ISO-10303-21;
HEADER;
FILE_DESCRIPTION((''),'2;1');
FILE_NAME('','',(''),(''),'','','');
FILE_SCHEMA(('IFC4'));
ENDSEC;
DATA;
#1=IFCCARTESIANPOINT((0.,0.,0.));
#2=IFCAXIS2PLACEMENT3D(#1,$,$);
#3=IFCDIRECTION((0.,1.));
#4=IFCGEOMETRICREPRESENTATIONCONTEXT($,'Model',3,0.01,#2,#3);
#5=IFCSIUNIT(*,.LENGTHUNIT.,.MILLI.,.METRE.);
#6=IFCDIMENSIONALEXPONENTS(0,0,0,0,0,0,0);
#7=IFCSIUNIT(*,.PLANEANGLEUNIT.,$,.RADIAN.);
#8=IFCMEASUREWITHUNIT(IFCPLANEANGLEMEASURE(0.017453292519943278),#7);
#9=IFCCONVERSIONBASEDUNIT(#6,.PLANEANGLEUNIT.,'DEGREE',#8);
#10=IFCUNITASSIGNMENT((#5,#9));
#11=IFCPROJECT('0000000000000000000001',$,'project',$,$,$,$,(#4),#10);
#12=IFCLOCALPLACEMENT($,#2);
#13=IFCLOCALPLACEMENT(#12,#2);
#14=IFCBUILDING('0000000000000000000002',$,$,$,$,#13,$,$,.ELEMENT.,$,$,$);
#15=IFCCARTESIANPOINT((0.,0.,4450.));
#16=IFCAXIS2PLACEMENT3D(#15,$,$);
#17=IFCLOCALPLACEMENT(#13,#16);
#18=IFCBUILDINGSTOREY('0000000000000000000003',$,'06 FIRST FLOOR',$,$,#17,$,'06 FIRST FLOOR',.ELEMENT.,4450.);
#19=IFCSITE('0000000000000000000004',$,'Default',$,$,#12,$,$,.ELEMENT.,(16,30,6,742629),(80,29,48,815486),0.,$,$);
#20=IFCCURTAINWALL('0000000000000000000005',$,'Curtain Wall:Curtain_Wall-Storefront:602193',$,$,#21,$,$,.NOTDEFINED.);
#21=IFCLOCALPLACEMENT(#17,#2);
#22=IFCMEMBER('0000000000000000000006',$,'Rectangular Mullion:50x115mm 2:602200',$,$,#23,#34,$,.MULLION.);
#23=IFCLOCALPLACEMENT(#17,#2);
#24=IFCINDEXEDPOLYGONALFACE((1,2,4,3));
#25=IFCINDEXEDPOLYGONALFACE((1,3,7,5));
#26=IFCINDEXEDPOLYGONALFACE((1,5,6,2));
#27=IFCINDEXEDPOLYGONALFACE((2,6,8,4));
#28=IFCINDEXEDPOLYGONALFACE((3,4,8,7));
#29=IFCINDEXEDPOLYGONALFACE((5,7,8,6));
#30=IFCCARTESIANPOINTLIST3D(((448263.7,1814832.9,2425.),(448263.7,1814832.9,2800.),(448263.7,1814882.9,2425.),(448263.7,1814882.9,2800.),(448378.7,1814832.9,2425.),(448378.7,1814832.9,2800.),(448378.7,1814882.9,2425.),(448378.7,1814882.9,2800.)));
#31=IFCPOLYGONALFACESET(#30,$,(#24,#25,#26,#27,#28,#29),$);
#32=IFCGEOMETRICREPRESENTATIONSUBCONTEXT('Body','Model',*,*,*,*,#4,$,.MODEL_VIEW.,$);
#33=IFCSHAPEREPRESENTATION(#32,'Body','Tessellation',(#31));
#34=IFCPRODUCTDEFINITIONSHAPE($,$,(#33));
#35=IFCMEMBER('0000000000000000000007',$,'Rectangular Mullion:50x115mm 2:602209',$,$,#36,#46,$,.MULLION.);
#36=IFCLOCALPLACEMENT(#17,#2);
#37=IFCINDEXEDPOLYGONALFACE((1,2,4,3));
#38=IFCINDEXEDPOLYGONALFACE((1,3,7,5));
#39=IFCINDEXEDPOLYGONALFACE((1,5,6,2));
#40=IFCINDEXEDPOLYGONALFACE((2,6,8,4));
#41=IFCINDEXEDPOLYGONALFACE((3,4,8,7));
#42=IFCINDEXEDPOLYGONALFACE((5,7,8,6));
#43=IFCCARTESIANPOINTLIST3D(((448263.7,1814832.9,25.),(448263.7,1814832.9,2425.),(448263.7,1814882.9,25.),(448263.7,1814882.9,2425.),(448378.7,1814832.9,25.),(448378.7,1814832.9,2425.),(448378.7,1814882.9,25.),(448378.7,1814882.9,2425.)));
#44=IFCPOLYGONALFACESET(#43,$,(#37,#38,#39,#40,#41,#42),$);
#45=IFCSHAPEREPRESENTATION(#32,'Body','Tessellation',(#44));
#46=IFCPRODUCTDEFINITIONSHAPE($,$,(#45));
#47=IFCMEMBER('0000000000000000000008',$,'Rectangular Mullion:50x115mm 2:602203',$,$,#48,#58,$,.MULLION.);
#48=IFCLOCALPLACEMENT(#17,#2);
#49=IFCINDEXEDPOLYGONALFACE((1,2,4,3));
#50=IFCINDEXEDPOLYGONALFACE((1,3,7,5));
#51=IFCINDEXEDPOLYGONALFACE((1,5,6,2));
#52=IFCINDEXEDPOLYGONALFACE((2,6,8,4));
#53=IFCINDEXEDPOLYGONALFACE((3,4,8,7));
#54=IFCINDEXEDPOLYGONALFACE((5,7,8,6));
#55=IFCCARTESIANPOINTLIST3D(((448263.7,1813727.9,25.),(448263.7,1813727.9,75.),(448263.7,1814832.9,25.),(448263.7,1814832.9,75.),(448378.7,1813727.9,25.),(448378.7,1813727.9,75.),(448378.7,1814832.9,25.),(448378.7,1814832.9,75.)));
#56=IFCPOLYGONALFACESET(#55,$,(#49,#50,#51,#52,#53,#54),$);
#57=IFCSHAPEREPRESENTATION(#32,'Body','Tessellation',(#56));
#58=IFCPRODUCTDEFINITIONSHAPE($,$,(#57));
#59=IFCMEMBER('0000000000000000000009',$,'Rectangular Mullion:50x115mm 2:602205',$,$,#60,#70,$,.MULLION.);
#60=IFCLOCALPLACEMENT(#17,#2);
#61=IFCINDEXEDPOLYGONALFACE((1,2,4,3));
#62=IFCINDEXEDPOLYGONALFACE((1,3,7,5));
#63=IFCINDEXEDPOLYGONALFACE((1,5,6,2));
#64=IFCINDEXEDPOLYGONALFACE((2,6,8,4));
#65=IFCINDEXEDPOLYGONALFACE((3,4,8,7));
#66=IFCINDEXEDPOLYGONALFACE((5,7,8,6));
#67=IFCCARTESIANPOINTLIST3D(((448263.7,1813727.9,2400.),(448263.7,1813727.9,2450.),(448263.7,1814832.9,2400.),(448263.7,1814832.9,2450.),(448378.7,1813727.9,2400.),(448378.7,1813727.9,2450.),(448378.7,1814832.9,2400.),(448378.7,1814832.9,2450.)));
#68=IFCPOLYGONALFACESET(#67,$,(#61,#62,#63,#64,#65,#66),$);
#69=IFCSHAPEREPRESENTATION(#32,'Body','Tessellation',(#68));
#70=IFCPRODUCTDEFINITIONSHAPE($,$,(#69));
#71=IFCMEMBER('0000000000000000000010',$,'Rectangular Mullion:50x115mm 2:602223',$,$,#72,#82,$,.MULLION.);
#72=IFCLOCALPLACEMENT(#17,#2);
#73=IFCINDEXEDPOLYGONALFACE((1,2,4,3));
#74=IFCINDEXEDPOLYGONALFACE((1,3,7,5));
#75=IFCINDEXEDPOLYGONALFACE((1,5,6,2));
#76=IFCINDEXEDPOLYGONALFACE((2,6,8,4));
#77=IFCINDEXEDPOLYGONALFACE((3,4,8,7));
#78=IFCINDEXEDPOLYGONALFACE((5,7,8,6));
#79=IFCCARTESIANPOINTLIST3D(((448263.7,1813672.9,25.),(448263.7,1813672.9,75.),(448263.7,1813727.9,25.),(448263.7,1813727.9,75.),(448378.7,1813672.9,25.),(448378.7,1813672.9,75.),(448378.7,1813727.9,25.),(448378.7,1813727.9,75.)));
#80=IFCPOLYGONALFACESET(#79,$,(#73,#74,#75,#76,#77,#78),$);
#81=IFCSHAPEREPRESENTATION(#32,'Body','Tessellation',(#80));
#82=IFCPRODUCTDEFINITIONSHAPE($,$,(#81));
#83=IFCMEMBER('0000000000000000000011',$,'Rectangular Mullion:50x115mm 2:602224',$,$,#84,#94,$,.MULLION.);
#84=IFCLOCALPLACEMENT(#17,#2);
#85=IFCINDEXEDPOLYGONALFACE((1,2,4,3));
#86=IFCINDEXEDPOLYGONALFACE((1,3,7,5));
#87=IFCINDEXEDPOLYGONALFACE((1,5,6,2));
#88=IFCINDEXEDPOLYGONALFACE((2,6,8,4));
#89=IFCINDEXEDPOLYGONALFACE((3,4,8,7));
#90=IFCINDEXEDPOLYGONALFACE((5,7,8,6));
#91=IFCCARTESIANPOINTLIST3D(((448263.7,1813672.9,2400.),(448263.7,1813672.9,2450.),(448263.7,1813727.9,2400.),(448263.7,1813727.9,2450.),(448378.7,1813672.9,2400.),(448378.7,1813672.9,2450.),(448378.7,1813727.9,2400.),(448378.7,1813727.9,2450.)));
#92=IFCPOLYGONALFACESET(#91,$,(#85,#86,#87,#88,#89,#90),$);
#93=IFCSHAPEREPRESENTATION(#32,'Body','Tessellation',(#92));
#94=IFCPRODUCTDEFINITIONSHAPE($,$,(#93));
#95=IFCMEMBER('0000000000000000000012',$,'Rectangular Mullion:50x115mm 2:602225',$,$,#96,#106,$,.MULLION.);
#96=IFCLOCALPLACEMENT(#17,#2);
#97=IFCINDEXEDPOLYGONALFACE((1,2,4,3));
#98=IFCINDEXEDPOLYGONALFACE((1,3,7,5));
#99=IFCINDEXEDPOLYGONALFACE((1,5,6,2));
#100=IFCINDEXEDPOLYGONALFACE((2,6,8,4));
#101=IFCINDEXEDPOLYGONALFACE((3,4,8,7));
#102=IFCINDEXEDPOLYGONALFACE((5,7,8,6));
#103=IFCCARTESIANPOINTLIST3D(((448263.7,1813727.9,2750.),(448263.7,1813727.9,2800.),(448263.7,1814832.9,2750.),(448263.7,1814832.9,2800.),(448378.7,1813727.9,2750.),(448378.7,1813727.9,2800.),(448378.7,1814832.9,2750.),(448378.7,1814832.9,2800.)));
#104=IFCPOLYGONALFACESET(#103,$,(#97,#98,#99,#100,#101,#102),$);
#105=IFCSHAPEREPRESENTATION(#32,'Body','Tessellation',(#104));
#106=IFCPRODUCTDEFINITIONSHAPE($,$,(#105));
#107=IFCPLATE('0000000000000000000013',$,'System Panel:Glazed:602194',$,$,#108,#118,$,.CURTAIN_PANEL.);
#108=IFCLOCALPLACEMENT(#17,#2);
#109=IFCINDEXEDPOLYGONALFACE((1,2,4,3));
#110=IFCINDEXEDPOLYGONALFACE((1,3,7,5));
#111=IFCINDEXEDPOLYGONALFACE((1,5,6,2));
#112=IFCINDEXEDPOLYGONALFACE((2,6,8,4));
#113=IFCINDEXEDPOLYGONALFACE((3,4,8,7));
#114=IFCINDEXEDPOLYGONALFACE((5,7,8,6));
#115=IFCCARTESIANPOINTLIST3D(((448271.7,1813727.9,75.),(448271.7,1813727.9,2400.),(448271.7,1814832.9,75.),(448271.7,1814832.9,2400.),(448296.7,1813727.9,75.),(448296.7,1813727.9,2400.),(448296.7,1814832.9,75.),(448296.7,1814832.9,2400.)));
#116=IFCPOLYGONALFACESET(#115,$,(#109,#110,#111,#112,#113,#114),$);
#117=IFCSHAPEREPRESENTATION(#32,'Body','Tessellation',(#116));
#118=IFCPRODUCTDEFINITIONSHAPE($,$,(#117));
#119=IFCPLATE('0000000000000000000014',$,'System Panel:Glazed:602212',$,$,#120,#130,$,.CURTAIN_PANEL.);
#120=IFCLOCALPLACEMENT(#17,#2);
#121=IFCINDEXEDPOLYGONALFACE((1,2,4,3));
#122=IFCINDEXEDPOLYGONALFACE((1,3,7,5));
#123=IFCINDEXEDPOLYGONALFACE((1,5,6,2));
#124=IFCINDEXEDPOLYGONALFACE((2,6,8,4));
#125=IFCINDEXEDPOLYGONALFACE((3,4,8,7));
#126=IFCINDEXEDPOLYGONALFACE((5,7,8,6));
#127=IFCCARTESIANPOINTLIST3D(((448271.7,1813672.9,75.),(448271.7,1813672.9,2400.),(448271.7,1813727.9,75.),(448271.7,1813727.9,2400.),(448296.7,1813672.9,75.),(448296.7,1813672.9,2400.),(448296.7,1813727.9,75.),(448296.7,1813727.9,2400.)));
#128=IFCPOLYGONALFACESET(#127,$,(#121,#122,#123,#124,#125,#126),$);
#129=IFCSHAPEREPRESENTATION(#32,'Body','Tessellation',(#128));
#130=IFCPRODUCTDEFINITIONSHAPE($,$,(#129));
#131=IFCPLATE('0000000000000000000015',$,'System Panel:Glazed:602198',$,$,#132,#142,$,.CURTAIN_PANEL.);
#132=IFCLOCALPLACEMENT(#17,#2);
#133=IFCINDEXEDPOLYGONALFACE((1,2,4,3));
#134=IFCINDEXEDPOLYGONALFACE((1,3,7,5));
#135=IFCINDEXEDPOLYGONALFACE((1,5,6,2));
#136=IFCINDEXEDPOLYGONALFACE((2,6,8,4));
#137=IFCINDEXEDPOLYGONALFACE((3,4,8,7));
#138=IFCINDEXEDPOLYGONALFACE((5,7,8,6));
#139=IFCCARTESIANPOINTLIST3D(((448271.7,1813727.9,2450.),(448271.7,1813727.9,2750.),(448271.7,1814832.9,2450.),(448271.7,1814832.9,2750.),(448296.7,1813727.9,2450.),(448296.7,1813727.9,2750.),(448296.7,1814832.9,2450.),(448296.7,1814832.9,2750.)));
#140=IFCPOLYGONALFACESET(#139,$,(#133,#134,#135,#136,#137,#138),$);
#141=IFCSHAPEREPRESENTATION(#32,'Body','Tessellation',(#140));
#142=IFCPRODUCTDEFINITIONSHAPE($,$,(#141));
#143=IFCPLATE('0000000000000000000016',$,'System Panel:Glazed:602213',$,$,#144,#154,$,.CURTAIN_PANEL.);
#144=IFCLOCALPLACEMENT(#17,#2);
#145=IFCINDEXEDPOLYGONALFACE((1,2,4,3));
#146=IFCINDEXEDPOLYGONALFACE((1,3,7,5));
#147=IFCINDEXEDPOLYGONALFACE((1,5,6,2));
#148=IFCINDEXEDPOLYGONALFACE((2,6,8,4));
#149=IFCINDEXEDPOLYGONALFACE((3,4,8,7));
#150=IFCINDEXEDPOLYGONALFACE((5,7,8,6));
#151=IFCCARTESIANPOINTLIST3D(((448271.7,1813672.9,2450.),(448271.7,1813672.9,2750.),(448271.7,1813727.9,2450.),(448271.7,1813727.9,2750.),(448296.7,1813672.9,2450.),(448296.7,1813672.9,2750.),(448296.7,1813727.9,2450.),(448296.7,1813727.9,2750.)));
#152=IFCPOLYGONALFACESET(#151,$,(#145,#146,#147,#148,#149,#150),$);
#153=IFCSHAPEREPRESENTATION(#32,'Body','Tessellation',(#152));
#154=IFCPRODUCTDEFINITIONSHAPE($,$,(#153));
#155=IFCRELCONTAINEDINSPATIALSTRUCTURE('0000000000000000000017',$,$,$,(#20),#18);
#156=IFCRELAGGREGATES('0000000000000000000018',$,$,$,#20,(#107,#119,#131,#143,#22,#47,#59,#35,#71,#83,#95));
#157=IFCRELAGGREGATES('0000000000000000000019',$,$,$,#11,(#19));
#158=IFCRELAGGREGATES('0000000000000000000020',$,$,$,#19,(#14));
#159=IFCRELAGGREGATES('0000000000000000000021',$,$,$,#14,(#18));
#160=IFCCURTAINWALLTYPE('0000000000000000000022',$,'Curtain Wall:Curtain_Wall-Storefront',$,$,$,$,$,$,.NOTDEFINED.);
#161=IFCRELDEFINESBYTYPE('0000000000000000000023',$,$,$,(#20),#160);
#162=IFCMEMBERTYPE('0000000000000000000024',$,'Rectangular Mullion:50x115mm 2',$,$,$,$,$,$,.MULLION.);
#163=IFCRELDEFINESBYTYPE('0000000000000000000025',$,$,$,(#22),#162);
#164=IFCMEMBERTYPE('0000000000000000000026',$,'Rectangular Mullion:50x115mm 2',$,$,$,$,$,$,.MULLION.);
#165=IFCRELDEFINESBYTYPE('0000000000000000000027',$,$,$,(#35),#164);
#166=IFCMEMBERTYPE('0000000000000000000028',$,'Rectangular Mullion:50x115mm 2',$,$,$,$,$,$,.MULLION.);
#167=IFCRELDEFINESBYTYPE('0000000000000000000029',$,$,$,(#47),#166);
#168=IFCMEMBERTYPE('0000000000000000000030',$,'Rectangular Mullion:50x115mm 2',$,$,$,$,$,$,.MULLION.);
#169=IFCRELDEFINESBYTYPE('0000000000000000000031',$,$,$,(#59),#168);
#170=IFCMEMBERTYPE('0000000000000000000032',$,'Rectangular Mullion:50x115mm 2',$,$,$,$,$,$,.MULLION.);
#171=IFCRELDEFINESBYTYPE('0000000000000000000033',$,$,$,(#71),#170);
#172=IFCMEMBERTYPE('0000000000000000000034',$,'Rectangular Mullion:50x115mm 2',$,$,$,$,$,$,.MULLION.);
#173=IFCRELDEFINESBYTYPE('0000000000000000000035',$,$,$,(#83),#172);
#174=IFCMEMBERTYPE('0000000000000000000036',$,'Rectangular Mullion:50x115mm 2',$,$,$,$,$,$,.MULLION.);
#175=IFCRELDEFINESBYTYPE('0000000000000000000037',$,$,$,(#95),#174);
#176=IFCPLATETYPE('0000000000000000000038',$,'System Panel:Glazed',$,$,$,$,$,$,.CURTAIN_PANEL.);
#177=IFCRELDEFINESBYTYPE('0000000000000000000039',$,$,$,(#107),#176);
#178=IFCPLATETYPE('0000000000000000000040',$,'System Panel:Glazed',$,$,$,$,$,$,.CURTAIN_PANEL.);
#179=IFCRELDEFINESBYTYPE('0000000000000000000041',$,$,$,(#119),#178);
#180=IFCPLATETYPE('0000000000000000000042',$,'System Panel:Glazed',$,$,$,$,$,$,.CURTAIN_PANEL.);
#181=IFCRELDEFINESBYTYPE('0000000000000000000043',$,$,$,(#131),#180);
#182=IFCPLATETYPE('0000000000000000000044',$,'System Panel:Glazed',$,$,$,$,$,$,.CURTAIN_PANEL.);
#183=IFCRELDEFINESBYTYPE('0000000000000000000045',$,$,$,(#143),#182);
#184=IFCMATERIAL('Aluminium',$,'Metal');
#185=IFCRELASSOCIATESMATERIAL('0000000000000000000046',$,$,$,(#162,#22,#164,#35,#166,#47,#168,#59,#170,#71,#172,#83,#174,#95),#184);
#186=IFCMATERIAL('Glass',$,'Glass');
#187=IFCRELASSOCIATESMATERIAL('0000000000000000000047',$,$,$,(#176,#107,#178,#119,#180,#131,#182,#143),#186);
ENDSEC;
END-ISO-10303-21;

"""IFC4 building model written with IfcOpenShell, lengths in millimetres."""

from ifc_helpers import new_model, entity, si_unit, converted_unit, direction, frame, origin, place, context, subcontext, project, spatial, indexed_curve, outline, extrude, source, transform, mapped, material, type_object, type_shapes, element, aggregate, save


model = new_model("IFC4")

# Units and contexts
model_context = context("Model", 3, precision=0.01, world=origin(), true_north=direction((0.0, 1.0)))
body_context = subcontext(model_context, "Body", "Model", "MODEL_VIEW")
ifc_project = project(units=[si_unit("LENGTHUNIT", "METRE", prefix="MILLI"), converted_unit("PLANEANGLEUNIT", "DEGREE", entity("IfcPlaneAngleMeasure", 0.017453292519943278), si_unit("PLANEANGLEUNIT", "RADIAN"), dimensions=[0, 0, 0, 0, 0, 0, 0])], contexts=[model_context])

# Site, building, storey
site_placement = place(None, origin())
site = spatial("IfcSite", under=ifc_project, at=site_placement, Name="Default", CompositionType="ELEMENT", RefLatitude=(16, 30, 6, 742629), RefLongitude=(80, 29, 48, 815486), RefElevation=0.0)
building_placement = place(site_placement, origin())
building = spatial("IfcBuilding", under=site, at=building_placement, CompositionType="ELEMENT")
storey_placement = place(building_placement, frame((0.0, 0.0, 4450.0)))
storey = spatial("IfcBuildingStorey", under=building, at=storey_placement, Name="06 FIRST FLOOR", LongName="06 FIRST FLOOR", CompositionType="ELEMENT", Elevation=4450.0)

# Curtain wall, members, plates
curtain_wall_type = type_object("IfcCurtainWallType", Name="Curtain Wall:Curtain_Wall-Storefront", PredefinedType="NOTDEFINED")
curtain_wall_placement = place(storey_placement, frame((0.0, 0.0, -4450.0)))
curtain_wall = element("IfcCurtainWall", 1, at=curtain_wall_placement, inside=storey, type_object=curtain_wall_type, Name="Curtain Wall:Curtain_Wall-Storefront:602193", PredefinedType="NOTDEFINED")
ifc_material_1 = material(Name="Aluminium", Category="Metal")
member_type_1 = type_object("IfcMemberType", Name="Rectangular Mullion:50x115mm 2", PredefinedType="MULLION", material=ifc_material_1)
shared_shape_1 = source(origin(), body_context, "Body", "SweptSolid", [
    extrude(outline(indexed_curve([(-25.0, -57.5), (25.0, -57.5), (25.0, 57.5), (-25.0, 57.5), (-25.0, -57.5)], self_intersect=False)), frame((-25.0, 0.0, -375.0), z_axis=(0.0, 0.0, 1.0), x_axis=(-1.0, 0.0, 0.0)), (0.0, 0.0, 1.0), 375.0),
])
type_shapes(member_type_1, [shared_shape_1])
member_1_placement = place(curtain_wall_placement, frame((448321.2, 1814882.9, 7250.0), z_axis=(0.0, 0.0, 1.0), x_axis=(0.0, 1.0, 0.0)))
member_1 = element("IfcMember", 2, at=member_1_placement, type_object=member_type_1, material=ifc_material_1, Name="Rectangular Mullion:50x115mm 2:602200", PredefinedType="MULLION", context=body_context, shape_type="MappedRepresentation", body=[
    mapped(shared_shape_1, transform((0.0, 0.0, 0.0), scale=1.0)),
])
member_type_2 = type_object("IfcMemberType", Name="Rectangular Mullion:50x115mm 2", PredefinedType="MULLION", material=ifc_material_1)
shared_shape_2 = source(origin(), body_context, "Body", "SweptSolid", [
    extrude(outline(indexed_curve([(-25.0, -57.5), (25.0, -57.5), (25.0, 57.5), (-25.0, 57.5), (-25.0, -57.5)], self_intersect=False)), frame((-25.0, 0.0, -2400.0), z_axis=(0.0, 0.0, 1.0), x_axis=(-1.0, 0.0, 0.0)), (0.0, 0.0, 1.0), 2400.0),
])
type_shapes(member_type_2, [shared_shape_2])
member_2_placement = place(curtain_wall_placement, frame((448321.2, 1814882.9, 6875.0), z_axis=(0.0, 0.0, 1.0), x_axis=(0.0, 1.0, 0.0)))
member_2 = element("IfcMember", 3, at=member_2_placement, type_object=member_type_2, material=ifc_material_1, Name="Rectangular Mullion:50x115mm 2:602209", PredefinedType="MULLION", context=body_context, shape_type="MappedRepresentation", body=[
    mapped(shared_shape_2, transform((0.0, 0.0, 0.0), scale=1.0)),
])
member_type_3 = type_object("IfcMemberType", Name="Rectangular Mullion:50x115mm 2", PredefinedType="MULLION", material=ifc_material_1)
shared_shape_3 = source(origin(), body_context, "Body", "SweptSolid", [
    extrude(outline(indexed_curve([(-25.0, -57.5), (25.0, -57.5), (25.0, 57.5), (-25.0, 57.5), (-25.0, -57.5)], self_intersect=False)), frame((-25.0, 0.0, -1105.0), z_axis=(0.0, 0.0, 1.0), x_axis=(-1.0, 0.0, 0.0)), (0.0, 0.0, 1.0), 1105.0),
])
type_shapes(member_type_3, [shared_shape_3])
member_3_placement = place(curtain_wall_placement, frame((448321.2, 1814832.9, 4475.0), z_axis=(0.0, 1.0, 0.0), x_axis=(0.0, 0.0, -1.0)))
member_3 = element("IfcMember", 4, at=member_3_placement, type_object=member_type_3, material=ifc_material_1, Name="Rectangular Mullion:50x115mm 2:602203", PredefinedType="MULLION", context=body_context, shape_type="MappedRepresentation", body=[
    mapped(shared_shape_3, transform((0.0, 0.0, 0.0), scale=1.0)),
])
member_type_4 = type_object("IfcMemberType", Name="Rectangular Mullion:50x115mm 2", PredefinedType="MULLION", material=ifc_material_1)
shared_shape_4 = source(origin(), body_context, "Body", "SweptSolid", [
    extrude(outline(indexed_curve([(-25.0, -57.5), (25.0, -57.5), (25.0, 57.5), (-25.0, 57.5), (-25.0, -57.5)], self_intersect=False)), frame((0.0, 0.0, -1105.0), z_axis=(0.0, 0.0, 1.0), x_axis=(-1.0, 0.0, 0.0)), (0.0, 0.0, 1.0), 1105.0),
])
type_shapes(member_type_4, [shared_shape_4])
member_4_placement = place(curtain_wall_placement, frame((448321.2, 1813727.9, 6875.0), z_axis=(0.0, -1.0, 0.0), x_axis=(0.0, 0.0, 1.0)))
member_4 = element("IfcMember", 5, at=member_4_placement, type_object=member_type_4, material=ifc_material_1, Name="Rectangular Mullion:50x115mm 2:602205", PredefinedType="MULLION", context=body_context, shape_type="MappedRepresentation", body=[
    mapped(shared_shape_4, transform((0.0, 0.0, 0.0), scale=1.0)),
])
member_type_5 = type_object("IfcMemberType", Name="Rectangular Mullion:50x115mm 2", PredefinedType="MULLION", material=ifc_material_1)
shared_shape_5 = source(origin(), body_context, "Body", "SweptSolid", [
    extrude(outline(indexed_curve([(-25.0, -57.5), (25.0, -57.5), (25.0, 57.5), (-25.0, 57.5), (-25.0, -57.5)], self_intersect=False)), frame((-25.0, 0.0, -55.0), z_axis=(0.0, 0.0, 1.0), x_axis=(-1.0, 0.0, 0.0)), (0.0, 0.0, 1.0), 55.0),
])
type_shapes(member_type_5, [shared_shape_5])
member_5_placement = place(curtain_wall_placement, frame((448321.2, 1813727.9, 4475.0), z_axis=(0.0, 1.0, 0.0), x_axis=(0.0, 0.0, -1.0)))
member_5 = element("IfcMember", 6, at=member_5_placement, type_object=member_type_5, material=ifc_material_1, Name="Rectangular Mullion:50x115mm 2:602223", PredefinedType="MULLION", context=body_context, shape_type="MappedRepresentation", body=[
    mapped(shared_shape_5, transform((0.0, 0.0, 0.0), scale=1.0)),
])
member_type_6 = type_object("IfcMemberType", Name="Rectangular Mullion:50x115mm 2", PredefinedType="MULLION", material=ifc_material_1)
shared_shape_6 = source(origin(), body_context, "Body", "SweptSolid", [
    extrude(outline(indexed_curve([(-25.0, -57.5), (25.0, -57.5), (25.0, 57.5), (-25.0, 57.5), (-25.0, -57.5)], self_intersect=False)), frame((0.0, 0.0, -55.0), z_axis=(0.0, 0.0, 1.0), x_axis=(-1.0, 0.0, 0.0)), (0.0, 0.0, 1.0), 55.0),
])
type_shapes(member_type_6, [shared_shape_6])
member_6_placement = place(curtain_wall_placement, frame((448321.2, 1813672.9, 6875.0), z_axis=(0.0, -1.0, 0.0), x_axis=(0.0, 0.0, 1.0)))
member_6 = element("IfcMember", 7, at=member_6_placement, type_object=member_type_6, material=ifc_material_1, Name="Rectangular Mullion:50x115mm 2:602224", PredefinedType="MULLION", context=body_context, shape_type="MappedRepresentation", body=[
    mapped(shared_shape_6, transform((0.0, 0.0, 0.0), scale=1.0)),
])
member_type_7 = type_object("IfcMemberType", Name="Rectangular Mullion:50x115mm 2", PredefinedType="MULLION", material=ifc_material_1)
shared_shape_7 = source(origin(), body_context, "Body", "SweptSolid", [
    extrude(outline(indexed_curve([(-25.0, -57.5), (25.0, -57.5), (25.0, 57.5), (-25.0, 57.5), (-25.0, -57.5)], self_intersect=False)), frame((-25.0, 0.0, -1105.0), z_axis=(0.0, 0.0, 1.0), x_axis=(-1.0, 0.0, 0.0)), (0.0, 0.0, 1.0), 1105.0),
])
type_shapes(member_type_7, [shared_shape_7])
member_7_placement = place(curtain_wall_placement, frame((448321.2, 1813727.9, 7250.0), z_axis=(0.0, -1.0, 0.0), x_axis=(0.0, 0.0, 1.0)))
member_7 = element("IfcMember", 8, at=member_7_placement, type_object=member_type_7, material=ifc_material_1, Name="Rectangular Mullion:50x115mm 2:602225", PredefinedType="MULLION", context=body_context, shape_type="MappedRepresentation", body=[
    mapped(shared_shape_7, transform((0.0, 0.0, 0.0), scale=1.0)),
])
ifc_material_2 = material(Name="Glass", Category="Glass")
plate_type_1 = type_object("IfcPlateType", Name="System Panel:Glazed", PredefinedType="CURTAIN_PANEL", material=ifc_material_2)
shared_shape_8 = source(origin(), body_context, "Body", "SweptSolid", [
    extrude(outline(indexed_curve([(-12.5, -552.5), (12.5, -552.5), (12.5, 552.5), (-12.5, 552.5), (-12.5, -552.5)], self_intersect=False)), frame((0.0, -37.0, 0.0), z_axis=(0.0, 0.0, 1.0), x_axis=(0.0, 1.0, 0.0)), (0.0, 0.0, 1.0), 2325.0),
])
type_shapes(plate_type_1, [shared_shape_8])
plate_1_placement = place(curtain_wall_placement, frame((448321.2, 1814280.4, 4525.0), z_axis=(0.0, 0.0, 1.0), x_axis=(0.0, -1.0, 0.0)))
plate_1 = element("IfcPlate", 9, at=plate_1_placement, type_object=plate_type_1, material=ifc_material_2, Name="System Panel:Glazed:602194", PredefinedType="CURTAIN_PANEL", context=body_context, shape_type="MappedRepresentation", body=[
    mapped(shared_shape_8, transform((0.0, 0.0, 0.0), scale=1.0)),
])
plate_type_2 = type_object("IfcPlateType", Name="System Panel:Glazed", PredefinedType="CURTAIN_PANEL", material=ifc_material_2)
shared_shape_9 = source(origin(), body_context, "Body", "SweptSolid", [
    extrude(outline(indexed_curve([(-12.5, -27.5), (12.5, -27.5), (12.5, 27.5), (-12.5, 27.5), (-12.5, -27.5)], self_intersect=False)), frame((0.0, -37.0, 0.0), z_axis=(0.0, 0.0, 1.0), x_axis=(0.0, 1.0, 0.0)), (0.0, 0.0, 1.0), 2325.0),
])
type_shapes(plate_type_2, [shared_shape_9])
plate_2_placement = place(curtain_wall_placement, frame((448321.2, 1813700.4, 4525.0), z_axis=(0.0, 0.0, 1.0), x_axis=(0.0, -1.0, 0.0)))
plate_2 = element("IfcPlate", 10, at=plate_2_placement, type_object=plate_type_2, material=ifc_material_2, Name="System Panel:Glazed:602212", PredefinedType="CURTAIN_PANEL", context=body_context, shape_type="MappedRepresentation", body=[
    mapped(shared_shape_9, transform((0.0, 0.0, 0.0), scale=1.0)),
])
plate_type_3 = type_object("IfcPlateType", Name="System Panel:Glazed", PredefinedType="CURTAIN_PANEL", material=ifc_material_2)
shared_shape_10 = source(origin(), body_context, "Body", "SweptSolid", [
    extrude(outline(indexed_curve([(-12.5, -552.5), (12.5, -552.5), (12.5, 552.5), (-12.5, 552.5), (-12.5, -552.5)], self_intersect=False)), frame((0.0, -37.0, 0.0), z_axis=(0.0, 0.0, 1.0), x_axis=(0.0, 1.0, 0.0)), (0.0, 0.0, 1.0), 300.0),
])
type_shapes(plate_type_3, [shared_shape_10])
plate_3_placement = place(curtain_wall_placement, frame((448321.2, 1814280.4, 6900.0), z_axis=(0.0, 0.0, 1.0), x_axis=(0.0, -1.0, 0.0)))
plate_3 = element("IfcPlate", 11, at=plate_3_placement, type_object=plate_type_3, material=ifc_material_2, Name="System Panel:Glazed:602198", PredefinedType="CURTAIN_PANEL", context=body_context, shape_type="MappedRepresentation", body=[
    mapped(shared_shape_10, transform((0.0, 0.0, 0.0), scale=1.0)),
])
plate_type_4 = type_object("IfcPlateType", Name="System Panel:Glazed", PredefinedType="CURTAIN_PANEL", material=ifc_material_2)
shared_shape_11 = source(origin(), body_context, "Body", "SweptSolid", [
    extrude(outline(indexed_curve([(-12.5, -27.5), (12.5, -27.5), (12.5, 27.5), (-12.5, 27.5), (-12.5, -27.5)], self_intersect=False)), frame((0.0, -37.0, 0.0), z_axis=(0.0, 0.0, 1.0), x_axis=(0.0, 1.0, 0.0)), (0.0, 0.0, 1.0), 300.0),
])
type_shapes(plate_type_4, [shared_shape_11])
plate_4_placement = place(curtain_wall_placement, frame((448321.2, 1813700.4, 6900.0), z_axis=(0.0, 0.0, 1.0), x_axis=(0.0, -1.0, 0.0)))
plate_4 = element("IfcPlate", 12, at=plate_4_placement, type_object=plate_type_4, material=ifc_material_2, Name="System Panel:Glazed:602213", PredefinedType="CURTAIN_PANEL", context=body_context, shape_type="MappedRepresentation", body=[
    mapped(shared_shape_11, transform((0.0, 0.0, 0.0), scale=1.0)),
])
aggregate(curtain_wall, [plate_1, plate_2, plate_3, plate_4, member_1, member_3, member_4, member_2, member_5, member_6, member_7])

save(model, "model.ifc")
